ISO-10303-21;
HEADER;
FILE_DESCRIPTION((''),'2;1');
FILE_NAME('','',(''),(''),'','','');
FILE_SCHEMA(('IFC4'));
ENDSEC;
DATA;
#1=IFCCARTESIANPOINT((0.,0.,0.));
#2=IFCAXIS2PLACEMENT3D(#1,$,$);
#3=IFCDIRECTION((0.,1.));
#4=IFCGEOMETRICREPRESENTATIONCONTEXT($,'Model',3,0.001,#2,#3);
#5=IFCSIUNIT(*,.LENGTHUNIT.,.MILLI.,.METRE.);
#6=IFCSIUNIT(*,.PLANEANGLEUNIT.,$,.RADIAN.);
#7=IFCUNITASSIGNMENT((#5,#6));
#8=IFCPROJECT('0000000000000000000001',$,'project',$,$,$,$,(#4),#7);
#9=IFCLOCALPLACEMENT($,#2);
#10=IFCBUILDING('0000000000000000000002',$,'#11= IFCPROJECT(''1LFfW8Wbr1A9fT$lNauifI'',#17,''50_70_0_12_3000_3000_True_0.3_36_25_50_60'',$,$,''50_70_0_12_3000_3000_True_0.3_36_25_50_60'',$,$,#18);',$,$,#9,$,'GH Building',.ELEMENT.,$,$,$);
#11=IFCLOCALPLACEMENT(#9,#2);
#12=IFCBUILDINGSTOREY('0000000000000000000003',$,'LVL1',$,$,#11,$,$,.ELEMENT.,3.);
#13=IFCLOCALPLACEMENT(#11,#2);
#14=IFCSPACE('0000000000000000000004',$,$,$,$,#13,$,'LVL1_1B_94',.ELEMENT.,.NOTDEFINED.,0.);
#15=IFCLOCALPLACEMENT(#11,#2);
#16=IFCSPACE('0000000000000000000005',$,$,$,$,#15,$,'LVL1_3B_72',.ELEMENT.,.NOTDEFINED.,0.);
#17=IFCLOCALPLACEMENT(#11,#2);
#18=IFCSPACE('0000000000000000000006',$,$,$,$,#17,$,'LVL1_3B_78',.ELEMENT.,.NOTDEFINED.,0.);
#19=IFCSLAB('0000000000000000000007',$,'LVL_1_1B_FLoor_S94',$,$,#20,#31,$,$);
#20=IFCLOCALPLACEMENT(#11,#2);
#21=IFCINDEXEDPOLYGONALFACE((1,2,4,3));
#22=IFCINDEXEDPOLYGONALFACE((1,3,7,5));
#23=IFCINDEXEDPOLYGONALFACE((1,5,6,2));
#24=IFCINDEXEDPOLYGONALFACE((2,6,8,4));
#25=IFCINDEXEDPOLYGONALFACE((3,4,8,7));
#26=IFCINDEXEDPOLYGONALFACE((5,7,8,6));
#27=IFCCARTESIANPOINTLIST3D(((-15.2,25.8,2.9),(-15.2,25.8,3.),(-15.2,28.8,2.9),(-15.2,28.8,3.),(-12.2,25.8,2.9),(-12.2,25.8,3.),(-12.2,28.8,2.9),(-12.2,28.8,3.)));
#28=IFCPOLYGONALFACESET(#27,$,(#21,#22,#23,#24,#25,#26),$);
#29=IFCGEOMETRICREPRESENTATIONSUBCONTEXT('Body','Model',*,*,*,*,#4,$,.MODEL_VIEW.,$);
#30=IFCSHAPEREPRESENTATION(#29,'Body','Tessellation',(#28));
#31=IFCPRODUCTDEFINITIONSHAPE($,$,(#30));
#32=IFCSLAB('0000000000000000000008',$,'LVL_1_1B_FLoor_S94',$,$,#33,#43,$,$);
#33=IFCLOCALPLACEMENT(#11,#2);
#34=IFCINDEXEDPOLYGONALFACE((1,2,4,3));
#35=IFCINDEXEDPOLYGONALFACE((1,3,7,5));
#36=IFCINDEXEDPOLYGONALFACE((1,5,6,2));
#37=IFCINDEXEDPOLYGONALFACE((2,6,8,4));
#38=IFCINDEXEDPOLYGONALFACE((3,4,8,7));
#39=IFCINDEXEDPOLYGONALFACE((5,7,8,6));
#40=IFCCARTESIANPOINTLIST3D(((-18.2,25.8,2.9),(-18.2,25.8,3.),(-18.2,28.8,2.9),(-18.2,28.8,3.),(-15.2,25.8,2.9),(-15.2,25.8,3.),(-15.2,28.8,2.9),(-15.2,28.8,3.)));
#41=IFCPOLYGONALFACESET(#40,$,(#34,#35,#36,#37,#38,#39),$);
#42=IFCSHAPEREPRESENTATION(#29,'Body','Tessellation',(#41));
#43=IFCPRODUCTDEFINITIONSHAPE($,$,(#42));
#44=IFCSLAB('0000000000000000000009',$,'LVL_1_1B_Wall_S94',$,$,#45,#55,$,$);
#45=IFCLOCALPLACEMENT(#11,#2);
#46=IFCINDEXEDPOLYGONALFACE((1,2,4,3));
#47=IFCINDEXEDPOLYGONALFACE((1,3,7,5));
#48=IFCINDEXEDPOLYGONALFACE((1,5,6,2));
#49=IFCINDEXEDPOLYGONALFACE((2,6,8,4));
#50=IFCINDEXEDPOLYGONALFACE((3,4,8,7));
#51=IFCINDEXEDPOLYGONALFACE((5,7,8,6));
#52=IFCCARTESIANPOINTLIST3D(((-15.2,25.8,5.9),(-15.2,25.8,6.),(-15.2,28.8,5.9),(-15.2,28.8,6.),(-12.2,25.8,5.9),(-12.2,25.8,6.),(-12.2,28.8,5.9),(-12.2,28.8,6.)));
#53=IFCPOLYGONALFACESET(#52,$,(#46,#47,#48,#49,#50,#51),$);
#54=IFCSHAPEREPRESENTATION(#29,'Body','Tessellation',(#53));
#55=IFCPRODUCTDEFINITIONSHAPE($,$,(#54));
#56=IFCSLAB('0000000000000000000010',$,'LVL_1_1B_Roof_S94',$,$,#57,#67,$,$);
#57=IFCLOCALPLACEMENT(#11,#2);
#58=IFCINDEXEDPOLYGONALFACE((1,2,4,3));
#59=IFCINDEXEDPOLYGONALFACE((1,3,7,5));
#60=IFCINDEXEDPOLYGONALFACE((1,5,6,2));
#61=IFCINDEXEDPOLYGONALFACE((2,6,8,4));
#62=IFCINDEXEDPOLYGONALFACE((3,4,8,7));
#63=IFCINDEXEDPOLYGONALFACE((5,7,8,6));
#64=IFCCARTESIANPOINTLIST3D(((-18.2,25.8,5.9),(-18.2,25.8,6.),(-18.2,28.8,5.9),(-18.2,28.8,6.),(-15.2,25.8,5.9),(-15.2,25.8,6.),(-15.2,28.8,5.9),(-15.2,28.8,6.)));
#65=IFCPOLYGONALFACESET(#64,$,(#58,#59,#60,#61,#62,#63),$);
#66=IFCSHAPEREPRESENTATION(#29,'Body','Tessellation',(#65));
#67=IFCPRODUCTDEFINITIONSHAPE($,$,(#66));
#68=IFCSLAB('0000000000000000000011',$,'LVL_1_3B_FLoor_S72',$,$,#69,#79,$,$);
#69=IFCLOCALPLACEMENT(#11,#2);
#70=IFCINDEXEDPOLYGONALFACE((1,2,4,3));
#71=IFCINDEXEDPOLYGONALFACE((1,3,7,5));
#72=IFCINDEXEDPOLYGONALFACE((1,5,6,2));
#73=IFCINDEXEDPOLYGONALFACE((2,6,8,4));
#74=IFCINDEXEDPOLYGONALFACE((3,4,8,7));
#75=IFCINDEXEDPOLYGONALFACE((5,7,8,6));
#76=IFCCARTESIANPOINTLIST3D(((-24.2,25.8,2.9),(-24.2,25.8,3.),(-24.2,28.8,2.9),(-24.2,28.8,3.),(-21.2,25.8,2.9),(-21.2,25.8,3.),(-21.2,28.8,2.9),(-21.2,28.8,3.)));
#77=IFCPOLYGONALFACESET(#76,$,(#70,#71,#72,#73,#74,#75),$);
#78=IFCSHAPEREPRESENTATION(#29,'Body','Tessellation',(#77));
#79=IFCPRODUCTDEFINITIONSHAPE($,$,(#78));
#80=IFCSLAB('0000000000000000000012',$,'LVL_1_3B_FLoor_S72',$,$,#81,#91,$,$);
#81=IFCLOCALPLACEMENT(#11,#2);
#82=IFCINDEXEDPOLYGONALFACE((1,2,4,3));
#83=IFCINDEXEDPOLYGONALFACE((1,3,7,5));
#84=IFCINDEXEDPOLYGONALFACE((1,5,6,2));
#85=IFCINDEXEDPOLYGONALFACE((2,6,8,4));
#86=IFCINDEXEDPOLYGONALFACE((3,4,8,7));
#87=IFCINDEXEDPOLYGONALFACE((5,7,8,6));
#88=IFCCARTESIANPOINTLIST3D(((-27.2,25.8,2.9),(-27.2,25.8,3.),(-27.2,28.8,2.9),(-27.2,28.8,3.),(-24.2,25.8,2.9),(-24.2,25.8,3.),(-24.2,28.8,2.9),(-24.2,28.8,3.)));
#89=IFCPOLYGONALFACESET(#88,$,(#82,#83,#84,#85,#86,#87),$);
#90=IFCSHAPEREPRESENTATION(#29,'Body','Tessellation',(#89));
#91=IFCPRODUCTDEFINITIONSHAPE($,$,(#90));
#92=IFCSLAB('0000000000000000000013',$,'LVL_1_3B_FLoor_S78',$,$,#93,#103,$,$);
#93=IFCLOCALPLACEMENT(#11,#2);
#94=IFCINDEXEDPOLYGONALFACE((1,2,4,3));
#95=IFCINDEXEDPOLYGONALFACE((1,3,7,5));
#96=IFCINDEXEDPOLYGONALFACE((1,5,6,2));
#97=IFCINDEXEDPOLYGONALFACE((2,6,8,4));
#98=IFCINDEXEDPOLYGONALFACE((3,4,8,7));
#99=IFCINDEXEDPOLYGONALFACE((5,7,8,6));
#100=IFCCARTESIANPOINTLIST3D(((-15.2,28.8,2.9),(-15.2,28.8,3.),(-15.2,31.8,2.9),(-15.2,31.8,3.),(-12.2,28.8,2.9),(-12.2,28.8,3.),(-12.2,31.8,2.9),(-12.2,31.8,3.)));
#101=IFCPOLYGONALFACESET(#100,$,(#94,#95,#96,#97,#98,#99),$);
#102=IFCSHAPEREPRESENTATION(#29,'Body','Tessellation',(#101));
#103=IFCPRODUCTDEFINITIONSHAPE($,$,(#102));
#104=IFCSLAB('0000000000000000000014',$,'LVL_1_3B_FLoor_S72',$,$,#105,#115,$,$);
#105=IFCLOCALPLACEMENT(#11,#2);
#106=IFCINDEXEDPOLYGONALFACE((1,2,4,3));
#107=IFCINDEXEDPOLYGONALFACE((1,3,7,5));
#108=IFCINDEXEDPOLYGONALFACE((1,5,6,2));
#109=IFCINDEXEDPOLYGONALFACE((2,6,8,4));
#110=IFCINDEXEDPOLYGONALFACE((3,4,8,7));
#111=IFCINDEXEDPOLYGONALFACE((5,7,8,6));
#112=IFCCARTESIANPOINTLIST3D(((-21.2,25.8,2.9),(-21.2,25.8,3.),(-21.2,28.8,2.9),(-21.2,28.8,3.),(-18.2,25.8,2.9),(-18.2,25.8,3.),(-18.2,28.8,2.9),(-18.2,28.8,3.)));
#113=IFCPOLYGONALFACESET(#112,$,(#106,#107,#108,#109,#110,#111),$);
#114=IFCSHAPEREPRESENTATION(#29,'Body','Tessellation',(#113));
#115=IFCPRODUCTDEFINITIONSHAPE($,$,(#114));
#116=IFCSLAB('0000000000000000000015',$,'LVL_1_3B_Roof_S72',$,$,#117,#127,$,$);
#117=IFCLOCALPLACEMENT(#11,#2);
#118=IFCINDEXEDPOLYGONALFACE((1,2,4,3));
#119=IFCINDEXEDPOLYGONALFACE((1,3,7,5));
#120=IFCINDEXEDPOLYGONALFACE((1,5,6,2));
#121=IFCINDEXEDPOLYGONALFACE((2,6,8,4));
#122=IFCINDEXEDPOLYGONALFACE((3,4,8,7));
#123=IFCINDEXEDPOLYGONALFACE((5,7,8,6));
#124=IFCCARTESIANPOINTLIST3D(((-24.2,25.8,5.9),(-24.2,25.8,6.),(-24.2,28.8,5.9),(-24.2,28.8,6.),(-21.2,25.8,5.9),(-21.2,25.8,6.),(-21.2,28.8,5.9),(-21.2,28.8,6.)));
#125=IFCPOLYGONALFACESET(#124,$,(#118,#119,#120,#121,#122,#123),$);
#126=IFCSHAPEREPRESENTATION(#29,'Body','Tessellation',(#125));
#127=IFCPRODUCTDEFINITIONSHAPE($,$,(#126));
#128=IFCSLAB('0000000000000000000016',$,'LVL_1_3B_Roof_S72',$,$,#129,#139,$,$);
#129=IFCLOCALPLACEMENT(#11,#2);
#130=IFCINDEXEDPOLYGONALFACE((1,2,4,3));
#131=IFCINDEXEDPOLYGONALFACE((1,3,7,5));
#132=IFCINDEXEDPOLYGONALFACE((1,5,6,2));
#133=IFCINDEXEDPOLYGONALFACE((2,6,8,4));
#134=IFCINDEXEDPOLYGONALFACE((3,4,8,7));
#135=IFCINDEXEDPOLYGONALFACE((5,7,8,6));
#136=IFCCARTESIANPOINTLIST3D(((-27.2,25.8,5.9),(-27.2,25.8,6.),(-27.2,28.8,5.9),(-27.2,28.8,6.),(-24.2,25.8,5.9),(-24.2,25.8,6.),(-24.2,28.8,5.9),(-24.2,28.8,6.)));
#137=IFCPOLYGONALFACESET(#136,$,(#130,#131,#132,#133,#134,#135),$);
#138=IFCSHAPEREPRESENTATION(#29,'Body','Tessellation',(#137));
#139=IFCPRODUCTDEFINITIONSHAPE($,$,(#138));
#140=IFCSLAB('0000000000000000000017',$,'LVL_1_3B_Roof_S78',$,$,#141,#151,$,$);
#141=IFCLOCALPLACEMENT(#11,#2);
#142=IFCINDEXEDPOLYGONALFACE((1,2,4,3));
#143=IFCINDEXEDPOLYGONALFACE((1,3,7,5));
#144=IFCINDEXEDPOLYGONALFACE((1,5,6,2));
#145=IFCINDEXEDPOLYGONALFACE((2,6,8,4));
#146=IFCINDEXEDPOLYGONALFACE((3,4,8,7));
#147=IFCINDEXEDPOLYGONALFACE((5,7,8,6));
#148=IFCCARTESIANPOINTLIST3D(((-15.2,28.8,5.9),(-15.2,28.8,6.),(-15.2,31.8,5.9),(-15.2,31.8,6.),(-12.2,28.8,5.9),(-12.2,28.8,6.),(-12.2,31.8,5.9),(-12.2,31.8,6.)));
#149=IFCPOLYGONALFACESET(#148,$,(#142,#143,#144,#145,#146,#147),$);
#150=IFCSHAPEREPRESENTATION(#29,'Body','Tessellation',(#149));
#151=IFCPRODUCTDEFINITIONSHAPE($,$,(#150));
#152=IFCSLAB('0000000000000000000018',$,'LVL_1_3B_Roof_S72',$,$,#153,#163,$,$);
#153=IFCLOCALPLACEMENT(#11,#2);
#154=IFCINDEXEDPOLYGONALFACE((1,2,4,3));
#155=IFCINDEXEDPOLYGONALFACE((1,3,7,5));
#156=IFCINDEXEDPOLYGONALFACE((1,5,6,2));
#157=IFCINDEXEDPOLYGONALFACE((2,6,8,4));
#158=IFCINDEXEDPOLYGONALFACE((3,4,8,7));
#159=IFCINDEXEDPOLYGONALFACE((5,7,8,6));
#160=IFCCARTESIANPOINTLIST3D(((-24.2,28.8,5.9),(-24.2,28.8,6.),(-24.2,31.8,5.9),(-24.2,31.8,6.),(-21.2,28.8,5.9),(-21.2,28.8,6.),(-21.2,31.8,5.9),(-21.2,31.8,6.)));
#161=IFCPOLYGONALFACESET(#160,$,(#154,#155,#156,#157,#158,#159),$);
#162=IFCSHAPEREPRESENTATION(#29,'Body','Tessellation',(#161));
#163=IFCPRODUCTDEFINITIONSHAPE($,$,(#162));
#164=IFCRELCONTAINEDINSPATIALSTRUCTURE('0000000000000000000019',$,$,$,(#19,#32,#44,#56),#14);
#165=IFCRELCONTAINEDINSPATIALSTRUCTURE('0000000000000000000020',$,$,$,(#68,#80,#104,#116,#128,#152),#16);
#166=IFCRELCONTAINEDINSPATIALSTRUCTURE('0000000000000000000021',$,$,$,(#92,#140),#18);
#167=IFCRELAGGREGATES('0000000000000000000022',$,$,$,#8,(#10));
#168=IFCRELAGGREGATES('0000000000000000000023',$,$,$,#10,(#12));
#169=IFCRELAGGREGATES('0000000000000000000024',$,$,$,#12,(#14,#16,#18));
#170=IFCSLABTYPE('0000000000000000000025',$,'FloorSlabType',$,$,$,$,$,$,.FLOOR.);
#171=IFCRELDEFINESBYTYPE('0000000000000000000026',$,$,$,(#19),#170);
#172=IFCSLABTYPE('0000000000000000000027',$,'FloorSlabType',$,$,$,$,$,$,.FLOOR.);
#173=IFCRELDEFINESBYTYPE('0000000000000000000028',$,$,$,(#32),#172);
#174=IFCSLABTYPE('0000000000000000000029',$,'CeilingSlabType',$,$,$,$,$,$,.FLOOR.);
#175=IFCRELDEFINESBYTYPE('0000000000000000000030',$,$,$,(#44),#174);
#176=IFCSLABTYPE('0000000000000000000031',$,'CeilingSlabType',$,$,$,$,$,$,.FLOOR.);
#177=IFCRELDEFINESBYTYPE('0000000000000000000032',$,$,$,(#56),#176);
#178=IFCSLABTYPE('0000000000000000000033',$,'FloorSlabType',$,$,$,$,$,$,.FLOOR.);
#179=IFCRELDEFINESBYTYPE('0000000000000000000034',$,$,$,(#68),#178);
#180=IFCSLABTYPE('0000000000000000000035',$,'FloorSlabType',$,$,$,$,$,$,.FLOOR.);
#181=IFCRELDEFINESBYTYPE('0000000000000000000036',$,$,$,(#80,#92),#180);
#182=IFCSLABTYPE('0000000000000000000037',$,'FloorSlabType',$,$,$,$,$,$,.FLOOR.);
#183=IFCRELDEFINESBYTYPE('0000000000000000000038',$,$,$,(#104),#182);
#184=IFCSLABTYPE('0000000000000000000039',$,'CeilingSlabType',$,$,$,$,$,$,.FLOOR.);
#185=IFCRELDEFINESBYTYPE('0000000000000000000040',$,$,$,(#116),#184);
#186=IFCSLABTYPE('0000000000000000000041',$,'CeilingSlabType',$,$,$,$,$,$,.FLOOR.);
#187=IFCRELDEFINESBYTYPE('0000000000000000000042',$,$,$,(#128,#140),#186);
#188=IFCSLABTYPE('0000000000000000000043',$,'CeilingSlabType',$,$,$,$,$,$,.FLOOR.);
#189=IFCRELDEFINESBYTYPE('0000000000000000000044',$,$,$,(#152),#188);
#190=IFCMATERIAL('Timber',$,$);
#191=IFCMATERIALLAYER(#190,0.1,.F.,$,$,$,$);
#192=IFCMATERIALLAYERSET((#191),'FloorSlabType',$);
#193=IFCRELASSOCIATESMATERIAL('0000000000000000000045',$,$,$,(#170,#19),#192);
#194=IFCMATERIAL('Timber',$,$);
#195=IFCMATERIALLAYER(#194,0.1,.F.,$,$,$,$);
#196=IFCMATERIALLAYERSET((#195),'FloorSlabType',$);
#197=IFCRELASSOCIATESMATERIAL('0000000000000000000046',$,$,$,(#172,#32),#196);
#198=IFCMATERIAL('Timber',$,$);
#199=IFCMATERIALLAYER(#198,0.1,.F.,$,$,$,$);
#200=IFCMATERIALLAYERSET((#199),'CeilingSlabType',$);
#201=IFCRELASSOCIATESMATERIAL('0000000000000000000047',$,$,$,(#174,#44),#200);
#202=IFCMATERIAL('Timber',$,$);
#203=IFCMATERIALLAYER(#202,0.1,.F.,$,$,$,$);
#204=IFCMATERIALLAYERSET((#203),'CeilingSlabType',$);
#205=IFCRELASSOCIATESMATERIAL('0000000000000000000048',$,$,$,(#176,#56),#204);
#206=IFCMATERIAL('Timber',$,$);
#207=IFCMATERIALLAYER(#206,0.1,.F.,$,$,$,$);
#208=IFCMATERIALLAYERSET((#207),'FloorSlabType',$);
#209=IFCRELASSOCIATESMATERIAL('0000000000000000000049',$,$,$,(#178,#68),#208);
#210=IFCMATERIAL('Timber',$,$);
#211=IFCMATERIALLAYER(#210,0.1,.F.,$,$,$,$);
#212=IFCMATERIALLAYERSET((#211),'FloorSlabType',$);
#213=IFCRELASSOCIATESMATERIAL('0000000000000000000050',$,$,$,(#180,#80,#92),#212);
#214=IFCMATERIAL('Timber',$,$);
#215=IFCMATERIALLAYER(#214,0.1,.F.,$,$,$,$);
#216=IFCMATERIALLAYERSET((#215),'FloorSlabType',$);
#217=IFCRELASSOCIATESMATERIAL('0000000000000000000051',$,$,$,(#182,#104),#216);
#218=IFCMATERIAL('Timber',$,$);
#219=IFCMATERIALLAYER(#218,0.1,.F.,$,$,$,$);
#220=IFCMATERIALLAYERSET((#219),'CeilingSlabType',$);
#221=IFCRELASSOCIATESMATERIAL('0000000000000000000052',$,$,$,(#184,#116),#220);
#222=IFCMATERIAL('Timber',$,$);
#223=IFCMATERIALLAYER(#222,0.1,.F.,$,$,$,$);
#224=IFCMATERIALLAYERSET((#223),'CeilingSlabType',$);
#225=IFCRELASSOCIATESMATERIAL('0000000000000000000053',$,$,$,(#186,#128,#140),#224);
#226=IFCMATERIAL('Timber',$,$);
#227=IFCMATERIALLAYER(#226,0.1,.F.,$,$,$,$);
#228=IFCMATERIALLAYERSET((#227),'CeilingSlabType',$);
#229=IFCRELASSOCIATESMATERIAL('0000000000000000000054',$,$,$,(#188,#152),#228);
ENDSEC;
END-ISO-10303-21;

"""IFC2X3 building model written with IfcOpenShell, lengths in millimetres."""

from ifc_helpers import new_model, si_unit, direction, frame, frame_2d, origin, place, context, subcontext, project, spatial, rectangle, extrude, material, layer, layer_set, layer_usage, type_object, element, save


model = new_model("IFC2X3")

# Units and contexts
model_context = context("Model", 3, precision=0.001, world=origin(), true_north=direction((0.0, 1.0)))
body_context = subcontext(model_context, "Body", "Model", "MODEL_VIEW")
ifc_project = project(units=[si_unit("LENGTHUNIT", "METRE", prefix="MILLI"), si_unit("PLANEANGLEUNIT", "RADIAN")], contexts=[model_context])

# Building, storey
building_placement = place(None, origin())
building = spatial("IfcBuilding", under=ifc_project, at=building_placement, Name="#11= IFCPROJECT('1LFfW8Wbr1A9fT$lNauifI',#17,'50_70_0_12_3000_3000_True_0.3_36_25_50_60',$,$,'50_70_0_12_3000_3000_True_0.3_36_25_50_60',$,$,#18);", LongName="GH Building", CompositionType="ELEMENT")
storey_placement = place(building_placement, origin())
storey = spatial("IfcBuildingStorey", under=building, at=storey_placement, Name="LVL1", CompositionType="ELEMENT", Elevation=3.0)

# Shared definitions
space_1_placement = place(storey_placement, origin())
space_1 = spatial("IfcSpace", under=storey, at=space_1_placement, LongName="LVL1_1B_94", CompositionType="ELEMENT", InteriorOrExteriorSpace="NOTDEFINED", ElevationWithFlooring=0.0)

# Slabs
ifc_material_1 = material(Name="Timber")
ifc_layer_1 = layer(ifc_material_1, 0.1, ventilated=False)
ifc_layer_set_1 = layer_set([ifc_layer_1], Name="FloorSlabType")
ifc_layer_usage_1 = layer_usage(ifc_layer_set_1, "AXIS3", "NEGATIVE", -0.1)
slab_type_1 = type_object("IfcSlabType", Name="FloorSlabType", PredefinedType="FLOOR", material=ifc_layer_set_1)
slab_1_placement = place(space_1_placement, frame((-12.2, 28.8, 2.9), z_axis=(0.0, 0.0, 1.0), x_axis=(-1.0, 0.0, 0.0)))
element("IfcSlab", 1, at=slab_1_placement, inside=space_1, type_object=slab_type_1, material=ifc_layer_usage_1, Name="LVL_1_1B_FLoor_S94", context=body_context, shape_type="SweptSolid", body=[
    extrude(rectangle(XDim=3.0, YDim=3.0, at=frame_2d((1.5, 1.5))), origin(), (0.0, 0.0, 1.0), 0.1),
])
ifc_material_2 = material(Name="Timber")
ifc_layer_2 = layer(ifc_material_2, 0.1, ventilated=False)
ifc_layer_set_2 = layer_set([ifc_layer_2], Name="FloorSlabType")
ifc_layer_usage_2 = layer_usage(ifc_layer_set_2, "AXIS3", "NEGATIVE", -0.1)
slab_type_2 = type_object("IfcSlabType", Name="FloorSlabType", PredefinedType="FLOOR", material=ifc_layer_set_2)
slab_2_placement = place(space_1_placement, frame((-15.2, 28.8, 2.9), z_axis=(0.0, 0.0, 1.0), x_axis=(-1.0, 0.0, 0.0)))
element("IfcSlab", 2, at=slab_2_placement, inside=space_1, type_object=slab_type_2, material=ifc_layer_usage_2, Name="LVL_1_1B_FLoor_S94", context=body_context, shape_type="SweptSolid", body=[
    extrude(rectangle(XDim=3.0, YDim=3.0, at=frame_2d((1.5, 1.5))), origin(), (0.0, 0.0, 1.0), 0.1),
])
ifc_material_3 = material(Name="Timber")
ifc_layer_3 = layer(ifc_material_3, 0.1, ventilated=False)
ifc_layer_set_3 = layer_set([ifc_layer_3], Name="CeilingSlabType")
ifc_layer_usage_3 = layer_usage(ifc_layer_set_3, "AXIS3", "NEGATIVE", -0.1)
slab_type_3 = type_object("IfcSlabType", Name="CeilingSlabType", PredefinedType="FLOOR", material=ifc_layer_set_3)
slab_3_placement = place(space_1_placement, frame((-12.2, 28.8, 5.9), z_axis=(0.0, 0.0, 1.0), x_axis=(-1.0, 0.0, 0.0)))
element("IfcSlab", 3, at=slab_3_placement, inside=space_1, type_object=slab_type_3, material=ifc_layer_usage_3, Name="LVL_1_1B_Wall_S94", context=body_context, shape_type="SweptSolid", body=[
    extrude(rectangle(XDim=3.0, YDim=3.0, at=frame_2d((1.5, 1.5))), origin(), (0.0, 0.0, 1.0), 0.1),
])
ifc_material_4 = material(Name="Timber")
ifc_layer_4 = layer(ifc_material_4, 0.1, ventilated=False)
ifc_layer_set_4 = layer_set([ifc_layer_4], Name="CeilingSlabType")
ifc_layer_usage_4 = layer_usage(ifc_layer_set_4, "AXIS3", "NEGATIVE", -0.1)
slab_type_4 = type_object("IfcSlabType", Name="CeilingSlabType", PredefinedType="FLOOR", material=ifc_layer_set_4)
slab_4_placement = place(space_1_placement, frame((-15.2, 28.8, 5.9), z_axis=(0.0, 0.0, 1.0), x_axis=(-1.0, 0.0, 0.0)))
element("IfcSlab", 4, at=slab_4_placement, inside=space_1, type_object=slab_type_4, material=ifc_layer_usage_4, Name="LVL_1_1B_Roof_S94", context=body_context, shape_type="SweptSolid", body=[
    extrude(rectangle(XDim=3.0, YDim=3.0, at=frame_2d((1.5, 1.5))), origin(), (0.0, 0.0, 1.0), 0.1),
])

# Shared definitions
space_2_placement = place(storey_placement, origin())
space_2 = spatial("IfcSpace", under=storey, at=space_2_placement, LongName="LVL1_3B_72", CompositionType="ELEMENT", InteriorOrExteriorSpace="NOTDEFINED", ElevationWithFlooring=0.0)

# Slabs
ifc_material_5 = material(Name="Timber")
ifc_layer_5 = layer(ifc_material_5, 0.1, ventilated=False)
ifc_layer_set_5 = layer_set([ifc_layer_5], Name="FloorSlabType")
ifc_layer_usage_5 = layer_usage(ifc_layer_set_5, "AXIS3", "NEGATIVE", -0.1)
slab_type_5 = type_object("IfcSlabType", Name="FloorSlabType", PredefinedType="FLOOR", material=ifc_layer_set_5)
slab_5_placement = place(space_2_placement, frame((-21.2, 28.8, 2.9), z_axis=(0.0, 0.0, 1.0), x_axis=(-1.0, 0.0, 0.0)))
element("IfcSlab", 5, at=slab_5_placement, inside=space_2, type_object=slab_type_5, material=ifc_layer_usage_5, Name="LVL_1_3B_FLoor_S72", context=body_context, shape_type="SweptSolid", body=[
    extrude(rectangle(XDim=3.0, YDim=3.0, at=frame_2d((1.5, 1.5))), origin(), (0.0, 0.0, 1.0), 0.1),
])
ifc_material_6 = material(Name="Timber")
ifc_layer_6 = layer(ifc_material_6, 0.1, ventilated=False)
ifc_layer_set_6 = layer_set([ifc_layer_6], Name="FloorSlabType")
ifc_layer_usage_6 = layer_usage(ifc_layer_set_6, "AXIS3", "NEGATIVE", -0.1)
slab_type_6 = type_object("IfcSlabType", Name="FloorSlabType", PredefinedType="FLOOR", material=ifc_layer_set_6)
slab_6_placement = place(space_2_placement, frame((-24.2, 28.8, 2.9), z_axis=(0.0, 0.0, 1.0), x_axis=(-1.0, 0.0, 0.0)))
element("IfcSlab", 6, at=slab_6_placement, inside=space_2, type_object=slab_type_6, material=ifc_layer_usage_6, Name="LVL_1_3B_FLoor_S72", context=body_context, shape_type="SweptSolid", body=[
    extrude(rectangle(XDim=3.0, YDim=3.0, at=frame_2d((1.5, 1.5))), origin(), (0.0, 0.0, 1.0), 0.1),
])

# Shared definitions
space_3_placement = place(storey_placement, origin())
space_3 = spatial("IfcSpace", under=storey, at=space_3_placement, LongName="LVL1_3B_78", CompositionType="ELEMENT", InteriorOrExteriorSpace="NOTDEFINED", ElevationWithFlooring=0.0)

# Slabs
ifc_layer_usage_7 = layer_usage(ifc_layer_set_6, "AXIS3", "NEGATIVE", -0.1)
slab_7_placement = place(space_3_placement, frame((-15.2, 31.8, 2.9), z_axis=(0.0, 0.0, 1.0), x_axis=(0.0, -1.0, 0.0)))
element("IfcSlab", 7, at=slab_7_placement, inside=space_3, type_object=slab_type_6, material=ifc_layer_usage_7, Name="LVL_1_3B_FLoor_S78", context=body_context, shape_type="SweptSolid", body=[
    extrude(rectangle(XDim=3.0, YDim=3.0, at=frame_2d((1.5, 1.5))), origin(), (0.0, 0.0, 1.0), 0.1),
])
ifc_material_7 = material(Name="Timber")
ifc_layer_7 = layer(ifc_material_7, 0.1, ventilated=False)
ifc_layer_set_7 = layer_set([ifc_layer_7], Name="FloorSlabType")
ifc_layer_usage_8 = layer_usage(ifc_layer_set_7, "AXIS3", "NEGATIVE", -0.1)
slab_type_7 = type_object("IfcSlabType", Name="FloorSlabType", PredefinedType="FLOOR", material=ifc_layer_set_7)
slab_8_placement = place(space_2_placement, frame((-18.2, 28.8, 2.9), z_axis=(0.0, 0.0, 1.0), x_axis=(-1.0, 0.0, 0.0)))
element("IfcSlab", 8, at=slab_8_placement, inside=space_2, type_object=slab_type_7, material=ifc_layer_usage_8, Name="LVL_1_3B_FLoor_S72", context=body_context, shape_type="SweptSolid", body=[
    extrude(rectangle(XDim=3.0, YDim=3.0, at=frame_2d((1.5, 1.5))), origin(), (0.0, 0.0, 1.0), 0.1),
])
ifc_material_8 = material(Name="Timber")
ifc_layer_8 = layer(ifc_material_8, 0.1, ventilated=False)
ifc_layer_set_8 = layer_set([ifc_layer_8], Name="CeilingSlabType")
ifc_layer_usage_9 = layer_usage(ifc_layer_set_8, "AXIS3", "NEGATIVE", -0.1)
slab_type_8 = type_object("IfcSlabType", Name="CeilingSlabType", PredefinedType="FLOOR", material=ifc_layer_set_8)
slab_9_placement = place(space_2_placement, frame((-21.2, 28.8, 5.9), z_axis=(0.0, 0.0, 1.0), x_axis=(-1.0, 0.0, 0.0)))
element("IfcSlab", 9, at=slab_9_placement, inside=space_2, type_object=slab_type_8, material=ifc_layer_usage_9, Name="LVL_1_3B_Roof_S72", context=body_context, shape_type="SweptSolid", body=[
    extrude(rectangle(XDim=3.0, YDim=3.0, at=frame_2d((1.5, 1.5))), origin(), (0.0, 0.0, 1.0), 0.1),
])
ifc_material_9 = material(Name="Timber")
ifc_layer_9 = layer(ifc_material_9, 0.1, ventilated=False)
ifc_layer_set_9 = layer_set([ifc_layer_9], Name="CeilingSlabType")
ifc_layer_usage_10 = layer_usage(ifc_layer_set_9, "AXIS3", "NEGATIVE", -0.1)
slab_type_9 = type_object("IfcSlabType", Name="CeilingSlabType", PredefinedType="FLOOR", material=ifc_layer_set_9)
slab_10_placement = place(space_2_placement, frame((-24.2, 28.8, 5.9), z_axis=(0.0, 0.0, 1.0), x_axis=(-1.0, 0.0, 0.0)))
element("IfcSlab", 10, at=slab_10_placement, inside=space_2, type_object=slab_type_9, material=ifc_layer_usage_10, Name="LVL_1_3B_Roof_S72", context=body_context, shape_type="SweptSolid", body=[
    extrude(rectangle(XDim=3.0, YDim=3.0, at=frame_2d((1.5, 1.5))), origin(), (0.0, 0.0, 1.0), 0.1),
])
ifc_layer_usage_11 = layer_usage(ifc_layer_set_9, "AXIS3", "NEGATIVE", -0.1)
slab_11_placement = place(space_3_placement, frame((-15.2, 31.8, 5.9), z_axis=(0.0, 0.0, 1.0), x_axis=(0.0, -1.0, 0.0)))
element("IfcSlab", 11, at=slab_11_placement, inside=space_3, type_object=slab_type_9, material=ifc_layer_usage_11, Name="LVL_1_3B_Roof_S78", context=body_context, shape_type="SweptSolid", body=[
    extrude(rectangle(XDim=3.0, YDim=3.0, at=frame_2d((1.5, 1.5))), origin(), (0.0, 0.0, 1.0), 0.1),
])
ifc_material_10 = material(Name="Timber")
ifc_layer_10 = layer(ifc_material_10, 0.1, ventilated=False)
ifc_layer_set_10 = layer_set([ifc_layer_10], Name="CeilingSlabType")
ifc_layer_usage_12 = layer_usage(ifc_layer_set_10, "AXIS3", "NEGATIVE", -0.1)
slab_type_10 = type_object("IfcSlabType", Name="CeilingSlabType", PredefinedType="FLOOR", material=ifc_layer_set_10)
slab_12_placement = place(space_2_placement, frame((-21.2, 31.8, 5.9), z_axis=(0.0, 0.0, 1.0), x_axis=(-1.0, 0.0, 0.0)))
element("IfcSlab", 12, at=slab_12_placement, inside=space_2, type_object=slab_type_10, material=ifc_layer_usage_12, Name="LVL_1_3B_Roof_S72", context=body_context, shape_type="SweptSolid", body=[
    extrude(rectangle(XDim=3.0, YDim=3.0, at=frame_2d((1.5, 1.5))), origin(), (0.0, 0.0, 1.0), 0.1),
])

save(model, "model.ifc")
